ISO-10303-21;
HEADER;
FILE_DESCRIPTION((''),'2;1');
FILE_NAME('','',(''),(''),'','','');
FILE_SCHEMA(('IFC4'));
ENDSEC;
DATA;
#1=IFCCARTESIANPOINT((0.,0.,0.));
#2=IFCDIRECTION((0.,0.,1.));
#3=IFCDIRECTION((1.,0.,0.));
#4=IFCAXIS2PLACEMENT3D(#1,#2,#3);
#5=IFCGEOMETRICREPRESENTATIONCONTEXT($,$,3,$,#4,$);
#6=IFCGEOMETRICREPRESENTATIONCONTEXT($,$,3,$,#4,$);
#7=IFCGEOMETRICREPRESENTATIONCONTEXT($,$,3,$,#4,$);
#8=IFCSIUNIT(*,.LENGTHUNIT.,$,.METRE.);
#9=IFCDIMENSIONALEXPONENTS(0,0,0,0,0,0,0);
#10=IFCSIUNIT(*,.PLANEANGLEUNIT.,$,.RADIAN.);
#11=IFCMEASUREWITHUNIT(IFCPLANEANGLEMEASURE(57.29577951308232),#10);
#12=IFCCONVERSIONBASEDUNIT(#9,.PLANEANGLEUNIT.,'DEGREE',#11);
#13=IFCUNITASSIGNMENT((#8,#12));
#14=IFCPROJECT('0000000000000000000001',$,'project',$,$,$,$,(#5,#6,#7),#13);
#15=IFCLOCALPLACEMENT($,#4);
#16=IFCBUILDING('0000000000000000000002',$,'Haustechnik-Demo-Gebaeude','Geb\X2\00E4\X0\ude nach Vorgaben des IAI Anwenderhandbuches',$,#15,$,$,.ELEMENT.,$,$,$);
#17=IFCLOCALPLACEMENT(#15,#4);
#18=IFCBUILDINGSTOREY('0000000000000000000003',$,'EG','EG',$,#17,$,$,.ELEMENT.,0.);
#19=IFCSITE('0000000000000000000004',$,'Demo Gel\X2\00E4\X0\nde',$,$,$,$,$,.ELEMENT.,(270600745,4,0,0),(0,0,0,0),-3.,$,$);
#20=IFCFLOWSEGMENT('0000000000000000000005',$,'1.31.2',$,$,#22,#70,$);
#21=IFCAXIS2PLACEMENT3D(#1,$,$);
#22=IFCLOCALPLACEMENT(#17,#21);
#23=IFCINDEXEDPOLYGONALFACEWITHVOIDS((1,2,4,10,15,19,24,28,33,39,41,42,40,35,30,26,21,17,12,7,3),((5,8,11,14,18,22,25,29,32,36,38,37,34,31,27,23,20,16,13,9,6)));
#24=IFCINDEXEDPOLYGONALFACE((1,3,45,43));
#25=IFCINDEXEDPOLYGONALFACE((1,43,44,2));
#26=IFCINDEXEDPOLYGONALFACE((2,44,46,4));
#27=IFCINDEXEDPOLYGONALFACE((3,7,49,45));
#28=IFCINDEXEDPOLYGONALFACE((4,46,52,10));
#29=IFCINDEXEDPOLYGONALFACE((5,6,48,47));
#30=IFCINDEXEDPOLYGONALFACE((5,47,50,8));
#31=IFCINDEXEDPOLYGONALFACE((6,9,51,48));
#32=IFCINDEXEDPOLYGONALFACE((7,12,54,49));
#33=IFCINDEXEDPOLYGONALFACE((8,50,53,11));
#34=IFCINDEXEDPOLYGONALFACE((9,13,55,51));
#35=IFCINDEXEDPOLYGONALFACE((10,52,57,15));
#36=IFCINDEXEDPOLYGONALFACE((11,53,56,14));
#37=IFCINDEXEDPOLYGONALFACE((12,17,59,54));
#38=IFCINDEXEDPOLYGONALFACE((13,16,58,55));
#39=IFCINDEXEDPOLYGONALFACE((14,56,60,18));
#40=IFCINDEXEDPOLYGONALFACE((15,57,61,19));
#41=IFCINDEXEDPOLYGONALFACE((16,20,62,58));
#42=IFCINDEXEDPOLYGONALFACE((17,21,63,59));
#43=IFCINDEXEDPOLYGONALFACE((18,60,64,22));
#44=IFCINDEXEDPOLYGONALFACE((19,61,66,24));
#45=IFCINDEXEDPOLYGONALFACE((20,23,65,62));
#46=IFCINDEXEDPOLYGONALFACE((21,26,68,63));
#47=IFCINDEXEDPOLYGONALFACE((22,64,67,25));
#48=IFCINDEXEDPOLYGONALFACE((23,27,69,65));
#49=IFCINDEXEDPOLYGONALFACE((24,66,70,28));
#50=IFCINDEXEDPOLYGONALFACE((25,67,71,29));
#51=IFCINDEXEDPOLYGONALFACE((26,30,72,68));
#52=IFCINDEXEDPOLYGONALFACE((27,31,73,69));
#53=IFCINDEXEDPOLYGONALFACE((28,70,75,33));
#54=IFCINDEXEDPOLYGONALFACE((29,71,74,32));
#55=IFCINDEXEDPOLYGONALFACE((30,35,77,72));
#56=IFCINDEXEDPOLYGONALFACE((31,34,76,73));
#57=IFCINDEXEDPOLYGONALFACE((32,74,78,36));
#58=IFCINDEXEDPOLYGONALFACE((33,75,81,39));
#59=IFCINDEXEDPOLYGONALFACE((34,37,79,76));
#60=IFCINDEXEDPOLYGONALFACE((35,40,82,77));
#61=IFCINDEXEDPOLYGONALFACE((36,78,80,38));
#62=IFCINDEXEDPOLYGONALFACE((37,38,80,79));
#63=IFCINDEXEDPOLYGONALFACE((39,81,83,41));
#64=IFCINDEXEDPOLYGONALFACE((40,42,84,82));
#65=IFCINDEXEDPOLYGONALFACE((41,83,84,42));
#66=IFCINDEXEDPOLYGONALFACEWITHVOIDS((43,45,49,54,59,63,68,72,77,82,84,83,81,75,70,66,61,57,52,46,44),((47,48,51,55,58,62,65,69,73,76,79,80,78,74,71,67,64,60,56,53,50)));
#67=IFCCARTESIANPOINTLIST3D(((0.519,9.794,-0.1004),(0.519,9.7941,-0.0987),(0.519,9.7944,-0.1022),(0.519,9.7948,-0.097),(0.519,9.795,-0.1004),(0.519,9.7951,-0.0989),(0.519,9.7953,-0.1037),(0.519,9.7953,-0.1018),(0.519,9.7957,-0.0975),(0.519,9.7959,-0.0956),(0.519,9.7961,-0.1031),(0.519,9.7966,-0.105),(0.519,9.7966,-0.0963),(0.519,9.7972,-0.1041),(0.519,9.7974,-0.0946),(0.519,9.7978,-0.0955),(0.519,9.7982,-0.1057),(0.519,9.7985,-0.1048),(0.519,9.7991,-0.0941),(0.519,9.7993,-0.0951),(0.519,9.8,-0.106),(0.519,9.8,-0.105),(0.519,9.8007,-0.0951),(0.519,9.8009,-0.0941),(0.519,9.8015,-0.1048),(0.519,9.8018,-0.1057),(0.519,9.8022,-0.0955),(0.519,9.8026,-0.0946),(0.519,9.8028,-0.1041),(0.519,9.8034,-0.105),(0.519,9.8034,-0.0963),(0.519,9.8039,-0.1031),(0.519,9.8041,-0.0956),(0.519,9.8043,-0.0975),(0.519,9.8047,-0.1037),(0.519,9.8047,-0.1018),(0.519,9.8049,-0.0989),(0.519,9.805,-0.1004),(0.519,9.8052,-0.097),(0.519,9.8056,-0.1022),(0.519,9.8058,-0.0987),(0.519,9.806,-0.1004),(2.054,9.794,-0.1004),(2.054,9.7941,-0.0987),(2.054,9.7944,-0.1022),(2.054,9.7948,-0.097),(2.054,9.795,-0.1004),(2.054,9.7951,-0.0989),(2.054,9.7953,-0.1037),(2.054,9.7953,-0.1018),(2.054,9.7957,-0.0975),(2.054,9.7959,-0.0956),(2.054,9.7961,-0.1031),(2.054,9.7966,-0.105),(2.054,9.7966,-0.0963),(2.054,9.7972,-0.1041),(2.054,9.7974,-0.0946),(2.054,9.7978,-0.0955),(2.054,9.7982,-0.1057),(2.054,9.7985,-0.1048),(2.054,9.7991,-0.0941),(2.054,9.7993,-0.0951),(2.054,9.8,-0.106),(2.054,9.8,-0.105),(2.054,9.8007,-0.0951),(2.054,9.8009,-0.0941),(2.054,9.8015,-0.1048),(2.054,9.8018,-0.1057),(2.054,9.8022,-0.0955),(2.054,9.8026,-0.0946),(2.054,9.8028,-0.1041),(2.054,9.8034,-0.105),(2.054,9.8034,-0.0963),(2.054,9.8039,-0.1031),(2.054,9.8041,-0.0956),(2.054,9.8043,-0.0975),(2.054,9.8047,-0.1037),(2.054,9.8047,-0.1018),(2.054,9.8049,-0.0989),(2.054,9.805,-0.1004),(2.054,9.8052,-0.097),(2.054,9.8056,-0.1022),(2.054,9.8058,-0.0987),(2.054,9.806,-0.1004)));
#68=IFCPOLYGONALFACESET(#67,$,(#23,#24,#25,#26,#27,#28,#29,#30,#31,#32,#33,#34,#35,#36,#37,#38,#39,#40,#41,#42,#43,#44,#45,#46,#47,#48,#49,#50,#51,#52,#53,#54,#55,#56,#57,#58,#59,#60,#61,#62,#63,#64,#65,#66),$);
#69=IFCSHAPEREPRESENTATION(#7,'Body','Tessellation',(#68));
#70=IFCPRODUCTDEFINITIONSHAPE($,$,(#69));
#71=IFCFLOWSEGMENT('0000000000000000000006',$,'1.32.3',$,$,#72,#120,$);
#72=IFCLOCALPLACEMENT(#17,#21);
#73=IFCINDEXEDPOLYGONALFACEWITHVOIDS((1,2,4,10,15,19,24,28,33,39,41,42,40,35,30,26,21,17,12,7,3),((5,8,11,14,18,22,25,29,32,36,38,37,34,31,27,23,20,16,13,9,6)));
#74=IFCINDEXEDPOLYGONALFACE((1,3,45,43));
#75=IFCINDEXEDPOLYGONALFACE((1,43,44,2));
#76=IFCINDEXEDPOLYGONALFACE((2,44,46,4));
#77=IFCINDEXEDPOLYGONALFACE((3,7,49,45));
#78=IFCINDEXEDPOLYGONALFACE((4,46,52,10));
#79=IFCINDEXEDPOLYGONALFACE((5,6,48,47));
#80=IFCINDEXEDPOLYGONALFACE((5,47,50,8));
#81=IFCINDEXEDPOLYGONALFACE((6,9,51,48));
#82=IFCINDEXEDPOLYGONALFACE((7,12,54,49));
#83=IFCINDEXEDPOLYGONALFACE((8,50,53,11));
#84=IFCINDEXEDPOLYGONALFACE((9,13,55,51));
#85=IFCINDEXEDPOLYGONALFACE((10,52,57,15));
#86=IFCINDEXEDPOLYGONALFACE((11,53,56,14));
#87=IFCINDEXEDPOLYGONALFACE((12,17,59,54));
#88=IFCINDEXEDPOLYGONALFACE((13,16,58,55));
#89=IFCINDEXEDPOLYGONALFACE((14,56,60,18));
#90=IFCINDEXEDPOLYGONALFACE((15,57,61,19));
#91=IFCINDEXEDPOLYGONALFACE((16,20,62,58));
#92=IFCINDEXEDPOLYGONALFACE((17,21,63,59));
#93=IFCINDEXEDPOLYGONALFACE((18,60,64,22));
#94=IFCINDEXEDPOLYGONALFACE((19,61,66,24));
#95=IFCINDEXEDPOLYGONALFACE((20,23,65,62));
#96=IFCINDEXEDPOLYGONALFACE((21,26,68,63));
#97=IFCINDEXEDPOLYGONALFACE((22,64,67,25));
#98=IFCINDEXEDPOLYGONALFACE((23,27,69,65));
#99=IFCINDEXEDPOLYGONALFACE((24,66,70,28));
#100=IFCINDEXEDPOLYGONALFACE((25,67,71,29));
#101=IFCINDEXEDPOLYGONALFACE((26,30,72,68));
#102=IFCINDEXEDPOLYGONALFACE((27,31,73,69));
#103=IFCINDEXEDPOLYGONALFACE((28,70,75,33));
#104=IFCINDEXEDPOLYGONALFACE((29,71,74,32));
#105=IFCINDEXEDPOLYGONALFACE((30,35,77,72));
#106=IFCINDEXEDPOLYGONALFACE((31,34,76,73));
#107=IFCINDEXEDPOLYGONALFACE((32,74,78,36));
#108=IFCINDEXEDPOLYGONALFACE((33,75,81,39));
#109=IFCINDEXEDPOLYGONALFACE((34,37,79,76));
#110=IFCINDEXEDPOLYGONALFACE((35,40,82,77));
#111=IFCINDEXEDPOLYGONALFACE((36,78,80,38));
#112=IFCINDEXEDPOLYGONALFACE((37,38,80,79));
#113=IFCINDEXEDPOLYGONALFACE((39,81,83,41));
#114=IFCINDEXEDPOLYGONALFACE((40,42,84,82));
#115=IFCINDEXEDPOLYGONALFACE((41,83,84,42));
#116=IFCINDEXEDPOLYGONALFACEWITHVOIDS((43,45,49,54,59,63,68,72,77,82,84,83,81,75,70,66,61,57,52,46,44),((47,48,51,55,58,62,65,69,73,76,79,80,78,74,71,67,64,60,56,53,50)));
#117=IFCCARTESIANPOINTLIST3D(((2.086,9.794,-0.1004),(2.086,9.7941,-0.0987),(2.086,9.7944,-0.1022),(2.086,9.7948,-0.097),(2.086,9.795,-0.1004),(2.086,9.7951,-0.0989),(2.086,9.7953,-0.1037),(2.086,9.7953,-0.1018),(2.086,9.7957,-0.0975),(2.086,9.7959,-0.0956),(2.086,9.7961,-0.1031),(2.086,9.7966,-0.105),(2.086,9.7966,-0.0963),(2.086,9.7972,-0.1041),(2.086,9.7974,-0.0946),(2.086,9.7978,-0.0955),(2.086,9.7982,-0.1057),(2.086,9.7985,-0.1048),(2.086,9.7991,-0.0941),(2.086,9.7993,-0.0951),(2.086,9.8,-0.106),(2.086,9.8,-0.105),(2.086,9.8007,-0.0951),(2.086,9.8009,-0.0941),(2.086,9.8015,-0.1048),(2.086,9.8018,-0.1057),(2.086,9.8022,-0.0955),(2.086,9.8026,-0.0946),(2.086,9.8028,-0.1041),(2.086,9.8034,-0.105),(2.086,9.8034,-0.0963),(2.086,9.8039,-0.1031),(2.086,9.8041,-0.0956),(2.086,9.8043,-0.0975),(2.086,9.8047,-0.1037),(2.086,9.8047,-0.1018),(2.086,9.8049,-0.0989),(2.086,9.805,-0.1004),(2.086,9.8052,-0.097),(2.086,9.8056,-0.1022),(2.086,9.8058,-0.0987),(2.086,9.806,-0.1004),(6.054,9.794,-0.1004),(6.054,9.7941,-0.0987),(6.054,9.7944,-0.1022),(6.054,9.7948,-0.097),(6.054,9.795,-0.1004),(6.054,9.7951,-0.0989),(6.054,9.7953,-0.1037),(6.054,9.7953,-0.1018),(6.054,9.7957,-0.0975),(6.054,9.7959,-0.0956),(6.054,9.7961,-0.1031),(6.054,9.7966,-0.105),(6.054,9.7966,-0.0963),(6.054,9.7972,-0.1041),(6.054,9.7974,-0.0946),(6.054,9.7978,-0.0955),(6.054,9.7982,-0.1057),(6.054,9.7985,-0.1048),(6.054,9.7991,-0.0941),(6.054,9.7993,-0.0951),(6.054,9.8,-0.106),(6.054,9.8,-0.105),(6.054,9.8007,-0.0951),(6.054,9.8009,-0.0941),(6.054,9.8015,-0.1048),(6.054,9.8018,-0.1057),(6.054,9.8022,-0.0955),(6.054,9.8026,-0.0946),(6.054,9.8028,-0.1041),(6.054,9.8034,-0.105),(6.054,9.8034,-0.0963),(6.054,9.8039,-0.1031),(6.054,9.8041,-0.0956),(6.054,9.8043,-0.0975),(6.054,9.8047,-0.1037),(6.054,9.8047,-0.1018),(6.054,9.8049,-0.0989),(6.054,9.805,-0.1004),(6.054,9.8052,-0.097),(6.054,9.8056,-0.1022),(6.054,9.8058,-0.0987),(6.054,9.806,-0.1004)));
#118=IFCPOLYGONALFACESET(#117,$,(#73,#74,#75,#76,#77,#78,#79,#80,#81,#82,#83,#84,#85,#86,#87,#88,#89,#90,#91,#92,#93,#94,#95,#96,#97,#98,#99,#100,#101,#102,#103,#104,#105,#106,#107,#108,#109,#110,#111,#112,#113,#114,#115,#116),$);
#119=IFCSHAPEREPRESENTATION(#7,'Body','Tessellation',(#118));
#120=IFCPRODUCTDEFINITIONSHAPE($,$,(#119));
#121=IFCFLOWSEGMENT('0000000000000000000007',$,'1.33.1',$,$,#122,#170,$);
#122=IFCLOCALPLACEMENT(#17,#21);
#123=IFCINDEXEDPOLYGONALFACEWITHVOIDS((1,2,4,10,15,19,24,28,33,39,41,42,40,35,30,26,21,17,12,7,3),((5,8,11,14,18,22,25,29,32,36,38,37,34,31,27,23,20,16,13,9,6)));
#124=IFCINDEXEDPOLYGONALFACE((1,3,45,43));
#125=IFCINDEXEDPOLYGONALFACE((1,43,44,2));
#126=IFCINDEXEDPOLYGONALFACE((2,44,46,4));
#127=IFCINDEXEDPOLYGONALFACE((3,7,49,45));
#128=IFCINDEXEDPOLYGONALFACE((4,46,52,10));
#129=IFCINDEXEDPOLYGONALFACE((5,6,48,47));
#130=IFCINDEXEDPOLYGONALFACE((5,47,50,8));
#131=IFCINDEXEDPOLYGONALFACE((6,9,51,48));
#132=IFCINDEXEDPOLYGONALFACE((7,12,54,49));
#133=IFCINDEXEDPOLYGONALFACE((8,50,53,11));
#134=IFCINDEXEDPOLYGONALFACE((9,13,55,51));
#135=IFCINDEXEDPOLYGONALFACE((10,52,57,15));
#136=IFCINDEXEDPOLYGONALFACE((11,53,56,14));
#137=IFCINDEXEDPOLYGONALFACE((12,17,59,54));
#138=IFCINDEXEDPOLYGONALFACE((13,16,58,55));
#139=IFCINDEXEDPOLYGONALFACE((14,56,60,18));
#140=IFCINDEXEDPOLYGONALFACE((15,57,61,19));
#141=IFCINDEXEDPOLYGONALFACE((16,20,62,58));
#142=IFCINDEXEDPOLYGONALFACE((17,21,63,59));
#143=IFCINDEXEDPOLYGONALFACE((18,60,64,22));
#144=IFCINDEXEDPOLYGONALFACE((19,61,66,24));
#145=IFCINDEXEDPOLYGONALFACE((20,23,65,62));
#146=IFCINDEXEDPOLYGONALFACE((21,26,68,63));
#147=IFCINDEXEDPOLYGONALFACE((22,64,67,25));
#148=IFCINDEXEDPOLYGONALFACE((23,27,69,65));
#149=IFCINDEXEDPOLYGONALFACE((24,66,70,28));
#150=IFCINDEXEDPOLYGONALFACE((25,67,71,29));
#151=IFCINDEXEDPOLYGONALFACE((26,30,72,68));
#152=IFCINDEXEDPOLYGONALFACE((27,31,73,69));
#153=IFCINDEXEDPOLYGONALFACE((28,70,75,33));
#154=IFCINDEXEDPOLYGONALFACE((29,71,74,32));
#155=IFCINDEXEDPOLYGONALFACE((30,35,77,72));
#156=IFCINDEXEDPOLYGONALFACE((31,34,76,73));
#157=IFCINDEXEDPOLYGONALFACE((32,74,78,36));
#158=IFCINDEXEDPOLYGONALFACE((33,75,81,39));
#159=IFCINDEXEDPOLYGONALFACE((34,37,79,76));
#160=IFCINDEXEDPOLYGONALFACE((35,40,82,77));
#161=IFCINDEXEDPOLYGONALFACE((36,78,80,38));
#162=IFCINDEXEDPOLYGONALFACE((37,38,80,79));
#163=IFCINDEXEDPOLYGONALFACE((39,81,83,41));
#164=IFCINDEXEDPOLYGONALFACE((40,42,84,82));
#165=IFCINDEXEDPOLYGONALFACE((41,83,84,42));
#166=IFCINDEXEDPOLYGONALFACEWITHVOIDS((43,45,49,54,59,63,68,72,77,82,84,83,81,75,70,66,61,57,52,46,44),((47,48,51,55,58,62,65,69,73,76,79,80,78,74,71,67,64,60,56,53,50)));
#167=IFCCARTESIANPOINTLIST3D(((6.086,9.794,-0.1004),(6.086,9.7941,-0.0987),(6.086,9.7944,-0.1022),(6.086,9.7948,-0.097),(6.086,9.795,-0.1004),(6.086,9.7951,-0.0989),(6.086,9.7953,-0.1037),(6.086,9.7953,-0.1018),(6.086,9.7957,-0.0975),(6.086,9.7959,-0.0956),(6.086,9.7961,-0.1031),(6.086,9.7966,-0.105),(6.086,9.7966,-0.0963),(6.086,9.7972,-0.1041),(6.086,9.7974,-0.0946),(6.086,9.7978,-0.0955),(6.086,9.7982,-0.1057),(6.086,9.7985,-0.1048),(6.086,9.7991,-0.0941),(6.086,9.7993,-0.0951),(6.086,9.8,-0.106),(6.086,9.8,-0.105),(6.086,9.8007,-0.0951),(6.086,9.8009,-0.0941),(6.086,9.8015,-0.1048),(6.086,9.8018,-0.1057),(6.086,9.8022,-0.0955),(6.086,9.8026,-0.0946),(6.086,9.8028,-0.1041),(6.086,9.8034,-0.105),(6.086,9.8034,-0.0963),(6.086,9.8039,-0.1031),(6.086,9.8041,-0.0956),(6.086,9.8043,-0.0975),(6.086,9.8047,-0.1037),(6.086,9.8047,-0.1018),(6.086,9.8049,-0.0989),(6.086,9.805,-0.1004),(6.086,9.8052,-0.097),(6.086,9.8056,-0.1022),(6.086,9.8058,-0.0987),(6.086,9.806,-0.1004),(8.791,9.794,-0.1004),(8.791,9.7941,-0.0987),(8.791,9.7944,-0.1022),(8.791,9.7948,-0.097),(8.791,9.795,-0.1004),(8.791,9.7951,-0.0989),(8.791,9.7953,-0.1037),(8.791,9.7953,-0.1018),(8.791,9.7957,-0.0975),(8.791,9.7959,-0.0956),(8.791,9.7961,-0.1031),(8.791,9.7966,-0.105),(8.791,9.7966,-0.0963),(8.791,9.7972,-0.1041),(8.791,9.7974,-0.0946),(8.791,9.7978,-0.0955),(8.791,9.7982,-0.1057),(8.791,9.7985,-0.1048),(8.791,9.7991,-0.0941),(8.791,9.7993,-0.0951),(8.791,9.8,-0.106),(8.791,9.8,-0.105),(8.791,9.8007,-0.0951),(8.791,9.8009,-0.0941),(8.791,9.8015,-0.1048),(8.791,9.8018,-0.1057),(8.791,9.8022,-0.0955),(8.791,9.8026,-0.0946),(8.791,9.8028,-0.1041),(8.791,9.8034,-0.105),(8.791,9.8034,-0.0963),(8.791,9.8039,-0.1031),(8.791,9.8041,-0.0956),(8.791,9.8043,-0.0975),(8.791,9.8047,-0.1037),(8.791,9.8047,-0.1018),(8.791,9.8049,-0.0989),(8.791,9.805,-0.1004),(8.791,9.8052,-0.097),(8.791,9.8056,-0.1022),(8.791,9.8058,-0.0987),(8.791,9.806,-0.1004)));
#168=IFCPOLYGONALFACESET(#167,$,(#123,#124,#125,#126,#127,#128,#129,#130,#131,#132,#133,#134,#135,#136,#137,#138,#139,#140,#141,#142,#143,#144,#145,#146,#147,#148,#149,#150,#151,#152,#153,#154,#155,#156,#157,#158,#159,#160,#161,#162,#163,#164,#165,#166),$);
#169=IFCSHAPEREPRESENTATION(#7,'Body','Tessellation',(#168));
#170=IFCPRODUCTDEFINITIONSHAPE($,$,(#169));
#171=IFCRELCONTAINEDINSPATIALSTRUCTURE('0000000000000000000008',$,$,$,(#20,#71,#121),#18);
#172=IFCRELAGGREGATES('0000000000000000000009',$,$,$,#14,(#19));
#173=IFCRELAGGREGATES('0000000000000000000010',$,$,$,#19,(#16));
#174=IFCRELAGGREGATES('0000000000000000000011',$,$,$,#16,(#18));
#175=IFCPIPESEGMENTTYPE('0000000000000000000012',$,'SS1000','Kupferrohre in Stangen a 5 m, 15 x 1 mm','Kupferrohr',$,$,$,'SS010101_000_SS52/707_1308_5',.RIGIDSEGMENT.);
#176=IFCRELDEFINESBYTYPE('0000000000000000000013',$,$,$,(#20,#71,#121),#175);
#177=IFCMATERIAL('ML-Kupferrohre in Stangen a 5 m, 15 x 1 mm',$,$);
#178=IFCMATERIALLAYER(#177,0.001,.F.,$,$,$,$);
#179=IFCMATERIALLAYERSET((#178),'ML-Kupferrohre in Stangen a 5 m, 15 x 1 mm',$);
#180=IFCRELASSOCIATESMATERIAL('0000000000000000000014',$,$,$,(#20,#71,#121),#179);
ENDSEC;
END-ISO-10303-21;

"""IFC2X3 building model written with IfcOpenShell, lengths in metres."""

from ifc_helpers import new_model, entity, si_unit, converted_unit, frame, origin_with_axes, origin_2d_with_axis, place, context, project, spatial, hollow_circle, extrude, material, layer, layer_set, layer_usage, type_object, element, save


model = new_model("IFC2X3")

# Units and contexts
context_of_model_1 = context(None, 3, world=origin_with_axes())
context_of_model_2 = context(None, 3, world=origin_with_axes())
context_of_model_3 = context(None, 3, world=origin_with_axes())
ifc_project = project(units=[si_unit("LENGTHUNIT", "METRE"), converted_unit("PLANEANGLEUNIT", "DEGREE", entity("IfcPlaneAngleMeasure", 57.29577951308232), si_unit("PLANEANGLEUNIT", "RADIAN"), dimensions=[0, 0, 0, 0, 0, 0, 0])], contexts=[context_of_model_1, context_of_model_2, context_of_model_3])

# Site, building, storey
site = spatial("IfcSite", under=ifc_project, Name="Demo Gelände", CompositionType="ELEMENT", RefLatitude=(270600745, 4, 0, 0), RefLongitude=(0, 0, 0, 0), RefElevation=-3.0)
building_placement = place(None, origin_with_axes())
building = spatial("IfcBuilding", under=site, at=building_placement, Name="Haustechnik-Demo-Gebaeude", Description="Gebäude nach Vorgaben des IAI Anwenderhandbuches", CompositionType="ELEMENT")
storey_placement = place(building_placement, origin_with_axes())
storey = spatial("IfcBuildingStorey", under=building, at=storey_placement, Name="EG", Description="EG", CompositionType="ELEMENT", Elevation=0.0)

# Flow segments
ifc_material_1 = material(Name="ML-Kupferrohre in Stangen a 5 m, 15 x 1 mm")
ifc_layer_1 = layer(ifc_material_1, 0.001, ventilated=False)
ifc_layer_set_1 = layer_set([ifc_layer_1], Name="ML-Kupferrohre in Stangen a 5 m, 15 x 1 mm")
ifc_layer_usage_1 = layer_usage(ifc_layer_set_1, "AXIS2", "POSITIVE", 0.0)
pipe_segment_type_1 = type_object("IfcPipeSegmentType", Name="SS1000", Description="Kupferrohre in Stangen a 5 m, 15 x 1 mm", ApplicableOccurrence="Kupferrohr", ElementType="SS010101_000_SS52/707_1308_5", PredefinedType="RIGIDSEGMENT")
flow_segment_1_placement = place(storey_placement, frame((0.519, 9.8, -0.1), z_axis=(1.0, 0.0, 0.0), x_axis=(0.0, 0.0, -1.0)))
element("IfcFlowSegment", 1, at=flow_segment_1_placement, inside=storey, type_object=pipe_segment_type_1, material=ifc_layer_usage_1, Name="1.31.2", context=context_of_model_3, shape_type="SweptSolid", body=[
    extrude(hollow_circle(Radius=0.006, WallThickness=0.001, at=origin_2d_with_axis()), origin_with_axes(), (0.0, 0.0, 1.0), 1.535),
])
flow_segment_2_placement = place(storey_placement, frame((2.086, 9.8, -0.1), z_axis=(1.0, 0.0, 0.0), x_axis=(0.0, 0.0, -1.0)))
element("IfcFlowSegment", 2, at=flow_segment_2_placement, inside=storey, type_object=pipe_segment_type_1, material=ifc_layer_usage_1, Name="1.32.3", context=context_of_model_3, shape_type="SweptSolid", body=[
    extrude(hollow_circle(Radius=0.006, WallThickness=0.001, at=origin_2d_with_axis()), origin_with_axes(), (0.0, 0.0, 1.0), 3.968),
])
flow_segment_3_placement = place(storey_placement, frame((6.086, 9.8, -0.1), z_axis=(1.0, 0.0, 0.0), x_axis=(0.0, 0.0, -1.0)))
element("IfcFlowSegment", 3, at=flow_segment_3_placement, inside=storey, type_object=pipe_segment_type_1, material=ifc_layer_usage_1, Name="1.33.1", context=context_of_model_3, shape_type="SweptSolid", body=[
    extrude(hollow_circle(Radius=0.006, WallThickness=0.001, at=origin_2d_with_axis()), origin_with_axes(), (0.0, 0.0, 1.0), 2.705),
])

save(model, "model.ifc")
